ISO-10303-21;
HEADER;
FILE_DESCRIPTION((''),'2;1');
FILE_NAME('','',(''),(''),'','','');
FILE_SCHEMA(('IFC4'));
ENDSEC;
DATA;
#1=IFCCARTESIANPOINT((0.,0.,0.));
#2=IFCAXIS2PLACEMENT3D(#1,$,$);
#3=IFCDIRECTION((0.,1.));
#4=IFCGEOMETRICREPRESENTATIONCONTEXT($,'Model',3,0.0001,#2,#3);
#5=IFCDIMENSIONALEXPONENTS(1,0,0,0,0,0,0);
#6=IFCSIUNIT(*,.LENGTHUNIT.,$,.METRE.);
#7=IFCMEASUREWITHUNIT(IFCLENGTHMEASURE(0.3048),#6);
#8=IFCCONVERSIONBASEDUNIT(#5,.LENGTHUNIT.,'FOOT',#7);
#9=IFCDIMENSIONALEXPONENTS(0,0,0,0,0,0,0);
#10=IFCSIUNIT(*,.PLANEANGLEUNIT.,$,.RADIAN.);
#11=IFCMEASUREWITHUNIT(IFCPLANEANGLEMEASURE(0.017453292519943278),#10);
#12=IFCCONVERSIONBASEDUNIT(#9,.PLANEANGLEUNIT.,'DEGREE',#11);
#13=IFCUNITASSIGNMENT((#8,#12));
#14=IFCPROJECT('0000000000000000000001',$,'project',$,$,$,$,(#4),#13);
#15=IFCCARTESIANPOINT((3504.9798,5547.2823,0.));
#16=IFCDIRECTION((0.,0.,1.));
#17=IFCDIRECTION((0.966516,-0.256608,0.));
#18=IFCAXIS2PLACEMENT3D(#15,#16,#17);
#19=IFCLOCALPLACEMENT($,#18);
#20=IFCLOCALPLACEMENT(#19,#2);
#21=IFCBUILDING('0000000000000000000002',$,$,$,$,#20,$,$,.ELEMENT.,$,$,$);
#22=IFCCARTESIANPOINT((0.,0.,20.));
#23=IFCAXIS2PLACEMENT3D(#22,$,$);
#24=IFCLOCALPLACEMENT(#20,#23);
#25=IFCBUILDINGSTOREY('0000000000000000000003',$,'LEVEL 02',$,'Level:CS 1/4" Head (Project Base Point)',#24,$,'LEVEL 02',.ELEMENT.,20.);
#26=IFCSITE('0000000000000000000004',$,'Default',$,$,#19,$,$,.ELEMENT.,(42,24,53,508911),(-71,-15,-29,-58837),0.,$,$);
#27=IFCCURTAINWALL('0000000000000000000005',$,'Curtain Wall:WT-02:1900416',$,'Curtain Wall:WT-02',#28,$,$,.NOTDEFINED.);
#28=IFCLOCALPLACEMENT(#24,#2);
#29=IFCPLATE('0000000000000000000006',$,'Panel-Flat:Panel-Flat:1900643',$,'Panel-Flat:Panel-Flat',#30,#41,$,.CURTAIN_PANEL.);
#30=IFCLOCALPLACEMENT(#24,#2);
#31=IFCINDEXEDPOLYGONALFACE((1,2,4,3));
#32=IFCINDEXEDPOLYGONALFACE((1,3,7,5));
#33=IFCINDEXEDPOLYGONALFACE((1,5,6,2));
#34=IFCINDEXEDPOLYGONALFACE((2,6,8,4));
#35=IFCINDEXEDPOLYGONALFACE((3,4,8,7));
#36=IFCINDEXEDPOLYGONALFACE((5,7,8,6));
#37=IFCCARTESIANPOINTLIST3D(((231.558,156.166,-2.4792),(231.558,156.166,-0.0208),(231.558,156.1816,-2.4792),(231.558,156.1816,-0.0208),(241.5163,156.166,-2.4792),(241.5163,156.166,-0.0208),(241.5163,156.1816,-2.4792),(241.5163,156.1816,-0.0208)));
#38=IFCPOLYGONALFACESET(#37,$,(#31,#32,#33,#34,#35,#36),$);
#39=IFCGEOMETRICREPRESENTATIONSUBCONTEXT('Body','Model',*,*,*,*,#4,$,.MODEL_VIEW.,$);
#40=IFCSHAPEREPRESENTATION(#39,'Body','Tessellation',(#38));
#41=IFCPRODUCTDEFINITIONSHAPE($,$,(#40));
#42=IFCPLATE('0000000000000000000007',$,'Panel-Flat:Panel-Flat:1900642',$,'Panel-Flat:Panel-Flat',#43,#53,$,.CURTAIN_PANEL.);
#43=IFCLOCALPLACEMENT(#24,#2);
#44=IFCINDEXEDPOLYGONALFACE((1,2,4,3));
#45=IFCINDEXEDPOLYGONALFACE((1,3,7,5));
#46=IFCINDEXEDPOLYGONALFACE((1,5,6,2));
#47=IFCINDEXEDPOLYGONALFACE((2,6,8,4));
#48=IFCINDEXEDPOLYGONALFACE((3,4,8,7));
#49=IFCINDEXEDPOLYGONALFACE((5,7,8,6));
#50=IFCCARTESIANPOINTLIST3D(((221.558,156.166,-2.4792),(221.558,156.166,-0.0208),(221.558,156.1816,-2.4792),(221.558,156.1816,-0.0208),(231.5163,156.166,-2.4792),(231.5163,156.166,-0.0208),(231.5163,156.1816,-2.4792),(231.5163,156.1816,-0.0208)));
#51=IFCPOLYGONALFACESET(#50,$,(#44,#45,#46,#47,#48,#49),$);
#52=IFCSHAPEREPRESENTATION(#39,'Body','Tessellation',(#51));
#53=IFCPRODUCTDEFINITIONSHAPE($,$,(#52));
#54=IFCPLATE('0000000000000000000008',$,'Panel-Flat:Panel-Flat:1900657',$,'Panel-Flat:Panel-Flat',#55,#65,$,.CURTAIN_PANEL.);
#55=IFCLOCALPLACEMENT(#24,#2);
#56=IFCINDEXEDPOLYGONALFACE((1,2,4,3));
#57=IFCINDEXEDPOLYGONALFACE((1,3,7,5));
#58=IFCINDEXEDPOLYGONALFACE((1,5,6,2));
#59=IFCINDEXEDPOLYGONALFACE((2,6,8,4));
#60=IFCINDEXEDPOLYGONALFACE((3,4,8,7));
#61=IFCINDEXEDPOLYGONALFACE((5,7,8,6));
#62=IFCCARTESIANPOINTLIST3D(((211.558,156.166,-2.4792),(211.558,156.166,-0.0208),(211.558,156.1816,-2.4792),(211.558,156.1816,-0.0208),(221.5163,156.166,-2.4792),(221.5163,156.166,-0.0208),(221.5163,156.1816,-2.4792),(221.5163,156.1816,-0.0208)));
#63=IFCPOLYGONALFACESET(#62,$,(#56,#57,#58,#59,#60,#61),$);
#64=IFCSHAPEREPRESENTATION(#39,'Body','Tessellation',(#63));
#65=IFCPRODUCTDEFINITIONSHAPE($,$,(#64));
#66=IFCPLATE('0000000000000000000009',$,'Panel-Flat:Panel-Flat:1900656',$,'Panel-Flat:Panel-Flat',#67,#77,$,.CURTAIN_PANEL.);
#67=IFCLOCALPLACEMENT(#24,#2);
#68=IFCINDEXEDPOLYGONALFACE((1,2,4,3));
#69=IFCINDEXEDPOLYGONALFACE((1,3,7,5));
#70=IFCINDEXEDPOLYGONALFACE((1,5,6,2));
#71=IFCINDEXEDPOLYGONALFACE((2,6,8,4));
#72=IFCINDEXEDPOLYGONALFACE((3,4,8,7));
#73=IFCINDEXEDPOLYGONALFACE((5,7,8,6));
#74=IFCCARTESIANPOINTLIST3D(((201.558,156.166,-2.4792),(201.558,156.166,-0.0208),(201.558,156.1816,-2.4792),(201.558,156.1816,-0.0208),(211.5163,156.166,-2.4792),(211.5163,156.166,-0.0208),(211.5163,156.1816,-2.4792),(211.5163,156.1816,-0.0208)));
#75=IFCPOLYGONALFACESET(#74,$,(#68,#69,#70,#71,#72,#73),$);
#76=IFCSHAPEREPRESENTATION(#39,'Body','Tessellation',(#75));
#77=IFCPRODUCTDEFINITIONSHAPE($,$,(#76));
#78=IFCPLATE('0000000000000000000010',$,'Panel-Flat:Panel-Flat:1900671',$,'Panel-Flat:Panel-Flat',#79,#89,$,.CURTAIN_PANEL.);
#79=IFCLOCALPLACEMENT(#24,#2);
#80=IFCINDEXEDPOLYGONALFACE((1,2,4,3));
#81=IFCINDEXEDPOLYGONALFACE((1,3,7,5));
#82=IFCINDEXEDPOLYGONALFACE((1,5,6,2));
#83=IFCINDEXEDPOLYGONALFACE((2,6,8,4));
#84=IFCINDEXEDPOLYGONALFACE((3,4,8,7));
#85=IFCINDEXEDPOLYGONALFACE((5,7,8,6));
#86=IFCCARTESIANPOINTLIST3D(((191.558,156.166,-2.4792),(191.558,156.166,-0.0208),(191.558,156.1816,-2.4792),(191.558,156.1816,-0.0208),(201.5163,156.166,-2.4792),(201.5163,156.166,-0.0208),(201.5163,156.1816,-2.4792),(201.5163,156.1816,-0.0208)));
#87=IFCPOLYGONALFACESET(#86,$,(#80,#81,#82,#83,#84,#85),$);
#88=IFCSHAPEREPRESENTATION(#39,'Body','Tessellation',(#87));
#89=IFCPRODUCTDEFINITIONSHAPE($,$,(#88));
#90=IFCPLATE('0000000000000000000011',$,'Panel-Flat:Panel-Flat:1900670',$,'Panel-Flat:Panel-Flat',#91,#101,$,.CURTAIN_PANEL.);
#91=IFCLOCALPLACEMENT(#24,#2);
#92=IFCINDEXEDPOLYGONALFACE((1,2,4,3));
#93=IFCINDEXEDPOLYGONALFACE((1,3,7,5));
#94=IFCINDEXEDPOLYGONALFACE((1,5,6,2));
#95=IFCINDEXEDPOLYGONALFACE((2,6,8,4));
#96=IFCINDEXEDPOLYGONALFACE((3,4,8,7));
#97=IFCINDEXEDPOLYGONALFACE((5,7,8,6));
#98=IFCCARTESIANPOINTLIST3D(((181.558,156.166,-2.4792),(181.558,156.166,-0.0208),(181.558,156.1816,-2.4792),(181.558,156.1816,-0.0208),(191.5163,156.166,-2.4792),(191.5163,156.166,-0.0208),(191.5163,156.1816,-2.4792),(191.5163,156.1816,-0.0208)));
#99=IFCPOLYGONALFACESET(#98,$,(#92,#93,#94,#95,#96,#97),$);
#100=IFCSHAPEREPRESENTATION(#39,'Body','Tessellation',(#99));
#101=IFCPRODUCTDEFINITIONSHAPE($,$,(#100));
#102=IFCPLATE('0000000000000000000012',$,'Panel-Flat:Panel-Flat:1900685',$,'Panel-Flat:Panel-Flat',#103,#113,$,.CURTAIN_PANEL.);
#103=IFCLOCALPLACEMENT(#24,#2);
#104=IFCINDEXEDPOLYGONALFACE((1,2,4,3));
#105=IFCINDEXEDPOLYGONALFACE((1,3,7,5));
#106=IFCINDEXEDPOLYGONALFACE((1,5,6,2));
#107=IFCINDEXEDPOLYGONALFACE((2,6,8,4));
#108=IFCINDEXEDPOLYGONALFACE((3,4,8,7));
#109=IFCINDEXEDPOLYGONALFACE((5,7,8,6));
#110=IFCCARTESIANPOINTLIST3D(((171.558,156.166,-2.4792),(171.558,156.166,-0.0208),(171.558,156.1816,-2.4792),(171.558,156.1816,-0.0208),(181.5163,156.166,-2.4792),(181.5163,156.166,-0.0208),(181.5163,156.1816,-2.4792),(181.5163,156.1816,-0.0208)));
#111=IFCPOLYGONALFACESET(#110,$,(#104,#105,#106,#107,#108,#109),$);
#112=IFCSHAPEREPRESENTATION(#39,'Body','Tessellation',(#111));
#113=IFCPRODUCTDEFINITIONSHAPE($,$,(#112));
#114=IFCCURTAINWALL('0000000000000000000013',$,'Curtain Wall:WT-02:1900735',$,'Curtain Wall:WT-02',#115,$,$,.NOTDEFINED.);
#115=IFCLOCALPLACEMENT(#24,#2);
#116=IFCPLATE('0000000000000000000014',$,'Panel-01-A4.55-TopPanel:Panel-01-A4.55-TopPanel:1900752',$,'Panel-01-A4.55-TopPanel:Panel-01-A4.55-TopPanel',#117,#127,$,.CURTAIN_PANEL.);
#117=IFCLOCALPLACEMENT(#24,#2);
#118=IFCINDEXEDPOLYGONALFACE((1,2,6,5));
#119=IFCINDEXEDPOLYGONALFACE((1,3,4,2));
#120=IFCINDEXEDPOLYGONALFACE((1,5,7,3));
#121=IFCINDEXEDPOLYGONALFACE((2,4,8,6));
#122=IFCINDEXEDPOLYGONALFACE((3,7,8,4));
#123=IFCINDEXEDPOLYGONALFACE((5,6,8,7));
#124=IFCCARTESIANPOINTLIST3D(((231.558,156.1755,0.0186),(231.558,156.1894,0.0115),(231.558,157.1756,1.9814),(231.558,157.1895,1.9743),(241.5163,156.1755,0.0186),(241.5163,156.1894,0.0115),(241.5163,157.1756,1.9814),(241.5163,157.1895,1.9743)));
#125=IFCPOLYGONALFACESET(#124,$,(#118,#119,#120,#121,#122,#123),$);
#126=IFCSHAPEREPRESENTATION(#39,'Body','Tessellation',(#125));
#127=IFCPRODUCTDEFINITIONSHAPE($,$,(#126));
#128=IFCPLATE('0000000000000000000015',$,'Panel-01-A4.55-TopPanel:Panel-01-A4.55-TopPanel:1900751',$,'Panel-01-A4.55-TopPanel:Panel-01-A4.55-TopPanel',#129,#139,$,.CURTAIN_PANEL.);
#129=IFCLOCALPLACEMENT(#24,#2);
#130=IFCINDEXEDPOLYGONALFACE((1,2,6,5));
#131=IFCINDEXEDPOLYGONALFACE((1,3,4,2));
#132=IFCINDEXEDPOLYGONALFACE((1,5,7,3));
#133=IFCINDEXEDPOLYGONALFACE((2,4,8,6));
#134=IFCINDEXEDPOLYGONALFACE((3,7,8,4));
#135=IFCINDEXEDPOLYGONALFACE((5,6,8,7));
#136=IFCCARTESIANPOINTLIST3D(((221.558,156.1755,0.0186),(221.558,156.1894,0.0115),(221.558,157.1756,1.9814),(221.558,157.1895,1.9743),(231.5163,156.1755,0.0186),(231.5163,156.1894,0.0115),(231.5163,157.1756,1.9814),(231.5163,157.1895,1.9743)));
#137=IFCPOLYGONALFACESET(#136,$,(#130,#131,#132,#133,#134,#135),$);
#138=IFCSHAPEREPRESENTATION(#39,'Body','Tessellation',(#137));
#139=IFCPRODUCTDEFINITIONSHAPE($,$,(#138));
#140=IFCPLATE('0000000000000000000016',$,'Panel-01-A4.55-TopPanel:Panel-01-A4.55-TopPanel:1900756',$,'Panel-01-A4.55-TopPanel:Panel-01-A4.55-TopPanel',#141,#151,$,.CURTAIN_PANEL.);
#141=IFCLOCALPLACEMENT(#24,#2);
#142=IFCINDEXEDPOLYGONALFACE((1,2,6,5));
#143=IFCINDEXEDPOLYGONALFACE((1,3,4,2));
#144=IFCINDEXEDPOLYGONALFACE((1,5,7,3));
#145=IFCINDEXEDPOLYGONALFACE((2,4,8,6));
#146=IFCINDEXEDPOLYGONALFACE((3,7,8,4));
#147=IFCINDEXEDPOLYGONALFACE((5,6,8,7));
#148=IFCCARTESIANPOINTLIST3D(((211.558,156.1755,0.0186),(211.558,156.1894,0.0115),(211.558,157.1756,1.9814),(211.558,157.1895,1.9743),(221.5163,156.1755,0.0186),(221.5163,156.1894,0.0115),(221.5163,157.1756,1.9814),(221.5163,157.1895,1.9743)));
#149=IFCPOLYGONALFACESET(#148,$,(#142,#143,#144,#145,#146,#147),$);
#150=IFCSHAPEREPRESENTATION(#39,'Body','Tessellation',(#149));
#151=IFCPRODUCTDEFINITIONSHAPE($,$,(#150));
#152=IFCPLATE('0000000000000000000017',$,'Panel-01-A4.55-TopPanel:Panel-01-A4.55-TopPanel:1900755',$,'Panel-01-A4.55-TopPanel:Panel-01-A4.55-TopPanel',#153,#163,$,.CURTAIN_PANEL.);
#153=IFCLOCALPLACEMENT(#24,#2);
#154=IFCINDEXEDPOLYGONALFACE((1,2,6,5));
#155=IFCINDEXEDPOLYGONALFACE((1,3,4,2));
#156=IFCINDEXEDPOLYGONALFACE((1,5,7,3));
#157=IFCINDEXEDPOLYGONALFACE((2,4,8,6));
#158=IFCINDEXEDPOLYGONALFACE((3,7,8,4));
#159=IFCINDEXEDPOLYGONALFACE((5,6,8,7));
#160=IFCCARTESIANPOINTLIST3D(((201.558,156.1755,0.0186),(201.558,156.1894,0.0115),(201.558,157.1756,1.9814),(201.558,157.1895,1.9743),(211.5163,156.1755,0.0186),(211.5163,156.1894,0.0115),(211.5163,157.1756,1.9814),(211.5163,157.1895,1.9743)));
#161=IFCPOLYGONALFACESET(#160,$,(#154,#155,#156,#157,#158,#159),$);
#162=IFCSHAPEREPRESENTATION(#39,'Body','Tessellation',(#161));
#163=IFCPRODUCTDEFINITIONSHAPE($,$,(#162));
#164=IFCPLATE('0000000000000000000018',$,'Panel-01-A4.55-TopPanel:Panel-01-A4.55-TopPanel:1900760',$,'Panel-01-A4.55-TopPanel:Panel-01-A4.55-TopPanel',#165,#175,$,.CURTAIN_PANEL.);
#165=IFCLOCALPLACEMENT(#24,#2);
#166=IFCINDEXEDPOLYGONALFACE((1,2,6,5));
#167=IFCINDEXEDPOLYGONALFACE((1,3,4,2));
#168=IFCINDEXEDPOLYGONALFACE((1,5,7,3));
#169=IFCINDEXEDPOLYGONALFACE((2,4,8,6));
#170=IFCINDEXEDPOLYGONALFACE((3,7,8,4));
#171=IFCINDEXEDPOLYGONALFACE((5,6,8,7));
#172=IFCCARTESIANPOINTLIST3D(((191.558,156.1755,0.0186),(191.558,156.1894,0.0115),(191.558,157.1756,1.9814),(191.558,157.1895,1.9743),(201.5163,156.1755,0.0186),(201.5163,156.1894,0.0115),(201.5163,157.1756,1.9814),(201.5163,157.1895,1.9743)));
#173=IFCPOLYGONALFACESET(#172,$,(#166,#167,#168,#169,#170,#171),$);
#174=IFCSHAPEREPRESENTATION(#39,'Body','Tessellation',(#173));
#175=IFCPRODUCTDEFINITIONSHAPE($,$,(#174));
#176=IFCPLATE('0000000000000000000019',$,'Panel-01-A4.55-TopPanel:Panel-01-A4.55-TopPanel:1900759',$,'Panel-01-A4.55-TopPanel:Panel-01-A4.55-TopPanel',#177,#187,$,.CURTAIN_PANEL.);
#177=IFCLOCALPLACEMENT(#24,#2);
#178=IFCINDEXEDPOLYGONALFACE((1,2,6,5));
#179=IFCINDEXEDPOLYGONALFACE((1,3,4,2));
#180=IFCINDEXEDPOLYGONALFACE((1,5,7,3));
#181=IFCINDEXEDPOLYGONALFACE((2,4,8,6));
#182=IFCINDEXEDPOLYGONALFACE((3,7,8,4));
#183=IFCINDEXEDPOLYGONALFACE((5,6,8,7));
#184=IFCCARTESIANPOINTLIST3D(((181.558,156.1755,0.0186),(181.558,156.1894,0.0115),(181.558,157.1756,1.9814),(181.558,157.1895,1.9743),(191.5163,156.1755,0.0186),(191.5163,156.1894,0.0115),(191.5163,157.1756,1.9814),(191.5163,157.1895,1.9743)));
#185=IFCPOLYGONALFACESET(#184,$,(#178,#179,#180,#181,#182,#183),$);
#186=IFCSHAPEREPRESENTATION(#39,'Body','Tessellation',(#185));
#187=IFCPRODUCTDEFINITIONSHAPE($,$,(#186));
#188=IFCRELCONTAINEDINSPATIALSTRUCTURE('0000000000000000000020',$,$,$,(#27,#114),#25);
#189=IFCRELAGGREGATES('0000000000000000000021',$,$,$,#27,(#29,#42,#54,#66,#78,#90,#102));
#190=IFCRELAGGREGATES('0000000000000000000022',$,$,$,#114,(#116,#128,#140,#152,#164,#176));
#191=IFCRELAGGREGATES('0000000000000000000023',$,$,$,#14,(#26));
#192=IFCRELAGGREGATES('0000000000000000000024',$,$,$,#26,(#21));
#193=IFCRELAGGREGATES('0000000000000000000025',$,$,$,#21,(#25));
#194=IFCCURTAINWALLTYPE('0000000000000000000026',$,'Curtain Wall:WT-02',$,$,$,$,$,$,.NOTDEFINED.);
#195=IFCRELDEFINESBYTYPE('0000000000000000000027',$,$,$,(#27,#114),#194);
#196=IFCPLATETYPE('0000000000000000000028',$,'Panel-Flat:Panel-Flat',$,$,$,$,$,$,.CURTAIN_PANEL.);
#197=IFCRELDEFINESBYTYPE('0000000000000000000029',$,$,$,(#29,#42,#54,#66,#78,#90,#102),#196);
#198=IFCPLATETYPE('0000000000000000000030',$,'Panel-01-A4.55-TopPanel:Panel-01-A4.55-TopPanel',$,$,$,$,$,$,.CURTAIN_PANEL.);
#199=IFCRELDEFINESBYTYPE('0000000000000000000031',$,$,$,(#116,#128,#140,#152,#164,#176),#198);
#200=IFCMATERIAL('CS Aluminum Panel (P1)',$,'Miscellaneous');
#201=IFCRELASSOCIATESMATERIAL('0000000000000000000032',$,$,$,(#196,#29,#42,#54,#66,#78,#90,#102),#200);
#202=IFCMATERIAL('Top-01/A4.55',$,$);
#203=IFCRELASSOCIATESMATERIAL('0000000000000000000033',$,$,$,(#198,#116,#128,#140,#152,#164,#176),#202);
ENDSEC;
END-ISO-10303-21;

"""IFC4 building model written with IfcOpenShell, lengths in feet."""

from ifc_helpers import new_model, entity, si_unit, converted_unit, direction, frame, origin, place, context, subcontext, project, spatial, indexed_curve, outline, extrude, source, transform, mapped, material, type_object, type_shapes, element, aggregate, save


model = new_model("IFC4")

# Units and contexts
model_context = context("Model", 3, precision=0.0001, world=origin(), true_north=direction((0.0, 1.0)))
body_context = subcontext(model_context, "Body", "Model", "MODEL_VIEW")
ifc_project = project(units=[converted_unit("LENGTHUNIT", "FOOT", entity("IfcLengthMeasure", 0.3048), si_unit("LENGTHUNIT", "METRE"), dimensions=[1, 0, 0, 0, 0, 0, 0]), converted_unit("PLANEANGLEUNIT", "DEGREE", entity("IfcPlaneAngleMeasure", 0.017453292519943278), si_unit("PLANEANGLEUNIT", "RADIAN"), dimensions=[0, 0, 0, 0, 0, 0, 0])], contexts=[model_context])

# Site, building, storey
site_placement = place(None, frame((3504.9798, 5547.2823, 0.0), z_axis=(0.0, 0.0, 1.0), x_axis=(0.966516, -0.256608, 0.0)))
site = spatial("IfcSite", under=ifc_project, at=site_placement, Name="Default", CompositionType="ELEMENT", RefLatitude=(42, 24, 53, 508911), RefLongitude=(-71, -15, -29, -58837), RefElevation=0.0)
building_placement = place(site_placement, origin())
building = spatial("IfcBuilding", under=site, at=building_placement, CompositionType="ELEMENT")
storey_placement = place(building_placement, frame((0.0, 0.0, 20.0)))
storey = spatial("IfcBuildingStorey", under=building, at=storey_placement, Name="LEVEL 02", ObjectType="Level:CS 1/4\" Head (Project Base Point)", LongName="LEVEL 02", CompositionType="ELEMENT", Elevation=20.0)

# Curtain walls, plates
curtain_wall_type_1 = type_object("IfcCurtainWallType", Name="Curtain Wall:WT-02", PredefinedType="NOTDEFINED")
curtain_wall_1_placement = place(storey_placement, frame((0.0, 0.0, -20.0)))
curtain_wall_1 = element("IfcCurtainWall", 1, at=curtain_wall_1_placement, inside=storey, type_object=curtain_wall_type_1, Name="Curtain Wall:WT-02:1900416", ObjectType="Curtain Wall:WT-02", PredefinedType="NOTDEFINED")
ifc_material_1 = material(Name="CS Aluminum Panel (P1)", Category="Miscellaneous")
plate_type_1 = type_object("IfcPlateType", Name="Panel-Flat:Panel-Flat", PredefinedType="CURTAIN_PANEL", material=ifc_material_1)
shared_shape_1 = source(origin(), body_context, "Body", "SweptSolid", [
    extrude(outline(indexed_curve([(-0.0078, -4.9792), (0.0078, -4.9792), (0.0078, 4.9792), (-0.0078, 4.9792), (-0.0078, -4.9792)], self_intersect=False)), frame((0.0, -0.0078, 0.0208), z_axis=(0.0, 0.0, 1.0), x_axis=(0.0, -1.0, 0.0)), (0.0, 0.0, 1.0), 2.4583),
])
type_shapes(plate_type_1, [shared_shape_1])
plate_1_placement = place(curtain_wall_1_placement, frame((236.5372, 156.166, 17.5), z_axis=(0.0, 0.0, 1.0), x_axis=(-1.0, 0.0, 0.0)))
plate_1 = element("IfcPlate", 2, at=plate_1_placement, type_object=plate_type_1, material=ifc_material_1, Name="Panel-Flat:Panel-Flat:1900643", ObjectType="Panel-Flat:Panel-Flat", PredefinedType="CURTAIN_PANEL", context=body_context, shape_type="MappedRepresentation", body=[
    mapped(shared_shape_1, transform((0.0, 0.0, 0.0), scale=1.0)),
])
plate_2_placement = place(curtain_wall_1_placement, frame((226.5372, 156.166, 17.5), z_axis=(0.0, 0.0, 1.0), x_axis=(-1.0, 0.0, 0.0)))
plate_2 = element("IfcPlate", 3, at=plate_2_placement, type_object=plate_type_1, material=ifc_material_1, Name="Panel-Flat:Panel-Flat:1900642", ObjectType="Panel-Flat:Panel-Flat", PredefinedType="CURTAIN_PANEL", context=body_context, shape_type="MappedRepresentation", body=[
    mapped(shared_shape_1, transform((0.0, 0.0, 0.0), scale=1.0)),
])
plate_3_placement = place(curtain_wall_1_placement, frame((216.5372, 156.166, 17.5), z_axis=(0.0, 0.0, 1.0), x_axis=(-1.0, 0.0, 0.0)))
plate_3 = element("IfcPlate", 4, at=plate_3_placement, type_object=plate_type_1, material=ifc_material_1, Name="Panel-Flat:Panel-Flat:1900657", ObjectType="Panel-Flat:Panel-Flat", PredefinedType="CURTAIN_PANEL", context=body_context, shape_type="MappedRepresentation", body=[
    mapped(shared_shape_1, transform((0.0, 0.0, 0.0), scale=1.0)),
])
plate_4_placement = place(curtain_wall_1_placement, frame((206.5372, 156.166, 17.5), z_axis=(0.0, 0.0, 1.0), x_axis=(-1.0, 0.0, 0.0)))
plate_4 = element("IfcPlate", 5, at=plate_4_placement, type_object=plate_type_1, material=ifc_material_1, Name="Panel-Flat:Panel-Flat:1900656", ObjectType="Panel-Flat:Panel-Flat", PredefinedType="CURTAIN_PANEL", context=body_context, shape_type="MappedRepresentation", body=[
    mapped(shared_shape_1, transform((0.0, 0.0, 0.0), scale=1.0)),
])
plate_5_placement = place(curtain_wall_1_placement, frame((196.5372, 156.166, 17.5), z_axis=(0.0, 0.0, 1.0), x_axis=(-1.0, 0.0, 0.0)))
plate_5 = element("IfcPlate", 6, at=plate_5_placement, type_object=plate_type_1, material=ifc_material_1, Name="Panel-Flat:Panel-Flat:1900671", ObjectType="Panel-Flat:Panel-Flat", PredefinedType="CURTAIN_PANEL", context=body_context, shape_type="MappedRepresentation", body=[
    mapped(shared_shape_1, transform((0.0, 0.0, 0.0), scale=1.0)),
])
plate_6_placement = place(curtain_wall_1_placement, frame((186.5372, 156.166, 17.5), z_axis=(0.0, 0.0, 1.0), x_axis=(-1.0, 0.0, 0.0)))
plate_6 = element("IfcPlate", 7, at=plate_6_placement, type_object=plate_type_1, material=ifc_material_1, Name="Panel-Flat:Panel-Flat:1900670", ObjectType="Panel-Flat:Panel-Flat", PredefinedType="CURTAIN_PANEL", context=body_context, shape_type="MappedRepresentation", body=[
    mapped(shared_shape_1, transform((0.0, 0.0, 0.0), scale=1.0)),
])
plate_7_placement = place(curtain_wall_1_placement, frame((176.5372, 156.166, 17.5), z_axis=(0.0, 0.0, 1.0), x_axis=(-1.0, 0.0, 0.0)))
plate_7 = element("IfcPlate", 8, at=plate_7_placement, type_object=plate_type_1, material=ifc_material_1, Name="Panel-Flat:Panel-Flat:1900685", ObjectType="Panel-Flat:Panel-Flat", PredefinedType="CURTAIN_PANEL", context=body_context, shape_type="MappedRepresentation", body=[
    mapped(shared_shape_1, transform((0.0, 0.0, 0.0), scale=1.0)),
])
aggregate(curtain_wall_1, [plate_1, plate_2, plate_3, plate_4, plate_5, plate_6, plate_7])
curtain_wall_2_placement = place(storey_placement, frame((0.0, 0.0, -20.0)))
curtain_wall_2 = element("IfcCurtainWall", 9, at=curtain_wall_2_placement, inside=storey, type_object=curtain_wall_type_1, Name="Curtain Wall:WT-02:1900735", ObjectType="Curtain Wall:WT-02", PredefinedType="NOTDEFINED")
ifc_material_2 = material(Name="Top-01/A4.55")
plate_type_2 = type_object("IfcPlateType", Name="Panel-01-A4.55-TopPanel:Panel-01-A4.55-TopPanel", PredefinedType="CURTAIN_PANEL", material=ifc_material_2)
shared_shape_2 = source(origin(), body_context, "Body", "SweptSolid", [
    extrude(outline(indexed_curve([(-0.0078, -4.9792), (0.0078, -4.9792), (0.0078, 4.9792), (-0.0078, 4.9792), (-0.0078, -4.9792)], self_intersect=False)), frame((0.0, -0.0078, 0.0208), z_axis=(0.0, 0.0, 1.0), x_axis=(0.0, -1.0, 0.0)), (0.0, 0.0, 1.0), 2.203),
])
type_shapes(plate_type_2, [shared_shape_2])
plate_8_placement = place(curtain_wall_2_placement, frame((236.5372, 156.166, 20.0), z_axis=(0.0, 0.45399, 0.891007), x_axis=(-1.0, 0.0, 0.0)))
plate_8 = element("IfcPlate", 10, at=plate_8_placement, type_object=plate_type_2, material=ifc_material_2, Name="Panel-01-A4.55-TopPanel:Panel-01-A4.55-TopPanel:1900752", ObjectType="Panel-01-A4.55-TopPanel:Panel-01-A4.55-TopPanel", PredefinedType="CURTAIN_PANEL", context=body_context, shape_type="MappedRepresentation", body=[
    mapped(shared_shape_2, transform((0.0, 0.0, 0.0), scale=1.0)),
])
plate_9_placement = place(curtain_wall_2_placement, frame((226.5372, 156.166, 20.0), z_axis=(0.0, 0.45399, 0.891007), x_axis=(-1.0, 0.0, 0.0)))
plate_9 = element("IfcPlate", 11, at=plate_9_placement, type_object=plate_type_2, material=ifc_material_2, Name="Panel-01-A4.55-TopPanel:Panel-01-A4.55-TopPanel:1900751", ObjectType="Panel-01-A4.55-TopPanel:Panel-01-A4.55-TopPanel", PredefinedType="CURTAIN_PANEL", context=body_context, shape_type="MappedRepresentation", body=[
    mapped(shared_shape_2, transform((0.0, 0.0, 0.0), scale=1.0)),
])
plate_10_placement = place(curtain_wall_2_placement, frame((216.5372, 156.166, 20.0), z_axis=(0.0, 0.45399, 0.891007), x_axis=(-1.0, 0.0, 0.0)))
plate_10 = element("IfcPlate", 12, at=plate_10_placement, type_object=plate_type_2, material=ifc_material_2, Name="Panel-01-A4.55-TopPanel:Panel-01-A4.55-TopPanel:1900756", ObjectType="Panel-01-A4.55-TopPanel:Panel-01-A4.55-TopPanel", PredefinedType="CURTAIN_PANEL", context=body_context, shape_type="MappedRepresentation", body=[
    mapped(shared_shape_2, transform((0.0, 0.0, 0.0), scale=1.0)),
])
plate_11_placement = place(curtain_wall_2_placement, frame((206.5372, 156.166, 20.0), z_axis=(0.0, 0.45399, 0.891007), x_axis=(-1.0, 0.0, 0.0)))
plate_11 = element("IfcPlate", 13, at=plate_11_placement, type_object=plate_type_2, material=ifc_material_2, Name="Panel-01-A4.55-TopPanel:Panel-01-A4.55-TopPanel:1900755", ObjectType="Panel-01-A4.55-TopPanel:Panel-01-A4.55-TopPanel", PredefinedType="CURTAIN_PANEL", context=body_context, shape_type="MappedRepresentation", body=[
    mapped(shared_shape_2, transform((0.0, 0.0, 0.0), scale=1.0)),
])
plate_12_placement = place(curtain_wall_2_placement, frame((196.5372, 156.166, 20.0), z_axis=(0.0, 0.45399, 0.891007), x_axis=(-1.0, 0.0, 0.0)))
plate_12 = element("IfcPlate", 14, at=plate_12_placement, type_object=plate_type_2, material=ifc_material_2, Name="Panel-01-A4.55-TopPanel:Panel-01-A4.55-TopPanel:1900760", ObjectType="Panel-01-A4.55-TopPanel:Panel-01-A4.55-TopPanel", PredefinedType="CURTAIN_PANEL", context=body_context, shape_type="MappedRepresentation", body=[
    mapped(shared_shape_2, transform((0.0, 0.0, 0.0), scale=1.0)),
])
plate_13_placement = place(curtain_wall_2_placement, frame((186.5372, 156.166, 20.0), z_axis=(0.0, 0.45399, 0.891007), x_axis=(-1.0, 0.0, 0.0)))
plate_13 = element("IfcPlate", 15, at=plate_13_placement, type_object=plate_type_2, material=ifc_material_2, Name="Panel-01-A4.55-TopPanel:Panel-01-A4.55-TopPanel:1900759", ObjectType="Panel-01-A4.55-TopPanel:Panel-01-A4.55-TopPanel", PredefinedType="CURTAIN_PANEL", context=body_context, shape_type="MappedRepresentation", body=[
    mapped(shared_shape_2, transform((0.0, 0.0, 0.0), scale=1.0)),
])
aggregate(curtain_wall_2, [plate_8, plate_9, plate_10, plate_11, plate_12, plate_13])

save(model, "model.ifc")
